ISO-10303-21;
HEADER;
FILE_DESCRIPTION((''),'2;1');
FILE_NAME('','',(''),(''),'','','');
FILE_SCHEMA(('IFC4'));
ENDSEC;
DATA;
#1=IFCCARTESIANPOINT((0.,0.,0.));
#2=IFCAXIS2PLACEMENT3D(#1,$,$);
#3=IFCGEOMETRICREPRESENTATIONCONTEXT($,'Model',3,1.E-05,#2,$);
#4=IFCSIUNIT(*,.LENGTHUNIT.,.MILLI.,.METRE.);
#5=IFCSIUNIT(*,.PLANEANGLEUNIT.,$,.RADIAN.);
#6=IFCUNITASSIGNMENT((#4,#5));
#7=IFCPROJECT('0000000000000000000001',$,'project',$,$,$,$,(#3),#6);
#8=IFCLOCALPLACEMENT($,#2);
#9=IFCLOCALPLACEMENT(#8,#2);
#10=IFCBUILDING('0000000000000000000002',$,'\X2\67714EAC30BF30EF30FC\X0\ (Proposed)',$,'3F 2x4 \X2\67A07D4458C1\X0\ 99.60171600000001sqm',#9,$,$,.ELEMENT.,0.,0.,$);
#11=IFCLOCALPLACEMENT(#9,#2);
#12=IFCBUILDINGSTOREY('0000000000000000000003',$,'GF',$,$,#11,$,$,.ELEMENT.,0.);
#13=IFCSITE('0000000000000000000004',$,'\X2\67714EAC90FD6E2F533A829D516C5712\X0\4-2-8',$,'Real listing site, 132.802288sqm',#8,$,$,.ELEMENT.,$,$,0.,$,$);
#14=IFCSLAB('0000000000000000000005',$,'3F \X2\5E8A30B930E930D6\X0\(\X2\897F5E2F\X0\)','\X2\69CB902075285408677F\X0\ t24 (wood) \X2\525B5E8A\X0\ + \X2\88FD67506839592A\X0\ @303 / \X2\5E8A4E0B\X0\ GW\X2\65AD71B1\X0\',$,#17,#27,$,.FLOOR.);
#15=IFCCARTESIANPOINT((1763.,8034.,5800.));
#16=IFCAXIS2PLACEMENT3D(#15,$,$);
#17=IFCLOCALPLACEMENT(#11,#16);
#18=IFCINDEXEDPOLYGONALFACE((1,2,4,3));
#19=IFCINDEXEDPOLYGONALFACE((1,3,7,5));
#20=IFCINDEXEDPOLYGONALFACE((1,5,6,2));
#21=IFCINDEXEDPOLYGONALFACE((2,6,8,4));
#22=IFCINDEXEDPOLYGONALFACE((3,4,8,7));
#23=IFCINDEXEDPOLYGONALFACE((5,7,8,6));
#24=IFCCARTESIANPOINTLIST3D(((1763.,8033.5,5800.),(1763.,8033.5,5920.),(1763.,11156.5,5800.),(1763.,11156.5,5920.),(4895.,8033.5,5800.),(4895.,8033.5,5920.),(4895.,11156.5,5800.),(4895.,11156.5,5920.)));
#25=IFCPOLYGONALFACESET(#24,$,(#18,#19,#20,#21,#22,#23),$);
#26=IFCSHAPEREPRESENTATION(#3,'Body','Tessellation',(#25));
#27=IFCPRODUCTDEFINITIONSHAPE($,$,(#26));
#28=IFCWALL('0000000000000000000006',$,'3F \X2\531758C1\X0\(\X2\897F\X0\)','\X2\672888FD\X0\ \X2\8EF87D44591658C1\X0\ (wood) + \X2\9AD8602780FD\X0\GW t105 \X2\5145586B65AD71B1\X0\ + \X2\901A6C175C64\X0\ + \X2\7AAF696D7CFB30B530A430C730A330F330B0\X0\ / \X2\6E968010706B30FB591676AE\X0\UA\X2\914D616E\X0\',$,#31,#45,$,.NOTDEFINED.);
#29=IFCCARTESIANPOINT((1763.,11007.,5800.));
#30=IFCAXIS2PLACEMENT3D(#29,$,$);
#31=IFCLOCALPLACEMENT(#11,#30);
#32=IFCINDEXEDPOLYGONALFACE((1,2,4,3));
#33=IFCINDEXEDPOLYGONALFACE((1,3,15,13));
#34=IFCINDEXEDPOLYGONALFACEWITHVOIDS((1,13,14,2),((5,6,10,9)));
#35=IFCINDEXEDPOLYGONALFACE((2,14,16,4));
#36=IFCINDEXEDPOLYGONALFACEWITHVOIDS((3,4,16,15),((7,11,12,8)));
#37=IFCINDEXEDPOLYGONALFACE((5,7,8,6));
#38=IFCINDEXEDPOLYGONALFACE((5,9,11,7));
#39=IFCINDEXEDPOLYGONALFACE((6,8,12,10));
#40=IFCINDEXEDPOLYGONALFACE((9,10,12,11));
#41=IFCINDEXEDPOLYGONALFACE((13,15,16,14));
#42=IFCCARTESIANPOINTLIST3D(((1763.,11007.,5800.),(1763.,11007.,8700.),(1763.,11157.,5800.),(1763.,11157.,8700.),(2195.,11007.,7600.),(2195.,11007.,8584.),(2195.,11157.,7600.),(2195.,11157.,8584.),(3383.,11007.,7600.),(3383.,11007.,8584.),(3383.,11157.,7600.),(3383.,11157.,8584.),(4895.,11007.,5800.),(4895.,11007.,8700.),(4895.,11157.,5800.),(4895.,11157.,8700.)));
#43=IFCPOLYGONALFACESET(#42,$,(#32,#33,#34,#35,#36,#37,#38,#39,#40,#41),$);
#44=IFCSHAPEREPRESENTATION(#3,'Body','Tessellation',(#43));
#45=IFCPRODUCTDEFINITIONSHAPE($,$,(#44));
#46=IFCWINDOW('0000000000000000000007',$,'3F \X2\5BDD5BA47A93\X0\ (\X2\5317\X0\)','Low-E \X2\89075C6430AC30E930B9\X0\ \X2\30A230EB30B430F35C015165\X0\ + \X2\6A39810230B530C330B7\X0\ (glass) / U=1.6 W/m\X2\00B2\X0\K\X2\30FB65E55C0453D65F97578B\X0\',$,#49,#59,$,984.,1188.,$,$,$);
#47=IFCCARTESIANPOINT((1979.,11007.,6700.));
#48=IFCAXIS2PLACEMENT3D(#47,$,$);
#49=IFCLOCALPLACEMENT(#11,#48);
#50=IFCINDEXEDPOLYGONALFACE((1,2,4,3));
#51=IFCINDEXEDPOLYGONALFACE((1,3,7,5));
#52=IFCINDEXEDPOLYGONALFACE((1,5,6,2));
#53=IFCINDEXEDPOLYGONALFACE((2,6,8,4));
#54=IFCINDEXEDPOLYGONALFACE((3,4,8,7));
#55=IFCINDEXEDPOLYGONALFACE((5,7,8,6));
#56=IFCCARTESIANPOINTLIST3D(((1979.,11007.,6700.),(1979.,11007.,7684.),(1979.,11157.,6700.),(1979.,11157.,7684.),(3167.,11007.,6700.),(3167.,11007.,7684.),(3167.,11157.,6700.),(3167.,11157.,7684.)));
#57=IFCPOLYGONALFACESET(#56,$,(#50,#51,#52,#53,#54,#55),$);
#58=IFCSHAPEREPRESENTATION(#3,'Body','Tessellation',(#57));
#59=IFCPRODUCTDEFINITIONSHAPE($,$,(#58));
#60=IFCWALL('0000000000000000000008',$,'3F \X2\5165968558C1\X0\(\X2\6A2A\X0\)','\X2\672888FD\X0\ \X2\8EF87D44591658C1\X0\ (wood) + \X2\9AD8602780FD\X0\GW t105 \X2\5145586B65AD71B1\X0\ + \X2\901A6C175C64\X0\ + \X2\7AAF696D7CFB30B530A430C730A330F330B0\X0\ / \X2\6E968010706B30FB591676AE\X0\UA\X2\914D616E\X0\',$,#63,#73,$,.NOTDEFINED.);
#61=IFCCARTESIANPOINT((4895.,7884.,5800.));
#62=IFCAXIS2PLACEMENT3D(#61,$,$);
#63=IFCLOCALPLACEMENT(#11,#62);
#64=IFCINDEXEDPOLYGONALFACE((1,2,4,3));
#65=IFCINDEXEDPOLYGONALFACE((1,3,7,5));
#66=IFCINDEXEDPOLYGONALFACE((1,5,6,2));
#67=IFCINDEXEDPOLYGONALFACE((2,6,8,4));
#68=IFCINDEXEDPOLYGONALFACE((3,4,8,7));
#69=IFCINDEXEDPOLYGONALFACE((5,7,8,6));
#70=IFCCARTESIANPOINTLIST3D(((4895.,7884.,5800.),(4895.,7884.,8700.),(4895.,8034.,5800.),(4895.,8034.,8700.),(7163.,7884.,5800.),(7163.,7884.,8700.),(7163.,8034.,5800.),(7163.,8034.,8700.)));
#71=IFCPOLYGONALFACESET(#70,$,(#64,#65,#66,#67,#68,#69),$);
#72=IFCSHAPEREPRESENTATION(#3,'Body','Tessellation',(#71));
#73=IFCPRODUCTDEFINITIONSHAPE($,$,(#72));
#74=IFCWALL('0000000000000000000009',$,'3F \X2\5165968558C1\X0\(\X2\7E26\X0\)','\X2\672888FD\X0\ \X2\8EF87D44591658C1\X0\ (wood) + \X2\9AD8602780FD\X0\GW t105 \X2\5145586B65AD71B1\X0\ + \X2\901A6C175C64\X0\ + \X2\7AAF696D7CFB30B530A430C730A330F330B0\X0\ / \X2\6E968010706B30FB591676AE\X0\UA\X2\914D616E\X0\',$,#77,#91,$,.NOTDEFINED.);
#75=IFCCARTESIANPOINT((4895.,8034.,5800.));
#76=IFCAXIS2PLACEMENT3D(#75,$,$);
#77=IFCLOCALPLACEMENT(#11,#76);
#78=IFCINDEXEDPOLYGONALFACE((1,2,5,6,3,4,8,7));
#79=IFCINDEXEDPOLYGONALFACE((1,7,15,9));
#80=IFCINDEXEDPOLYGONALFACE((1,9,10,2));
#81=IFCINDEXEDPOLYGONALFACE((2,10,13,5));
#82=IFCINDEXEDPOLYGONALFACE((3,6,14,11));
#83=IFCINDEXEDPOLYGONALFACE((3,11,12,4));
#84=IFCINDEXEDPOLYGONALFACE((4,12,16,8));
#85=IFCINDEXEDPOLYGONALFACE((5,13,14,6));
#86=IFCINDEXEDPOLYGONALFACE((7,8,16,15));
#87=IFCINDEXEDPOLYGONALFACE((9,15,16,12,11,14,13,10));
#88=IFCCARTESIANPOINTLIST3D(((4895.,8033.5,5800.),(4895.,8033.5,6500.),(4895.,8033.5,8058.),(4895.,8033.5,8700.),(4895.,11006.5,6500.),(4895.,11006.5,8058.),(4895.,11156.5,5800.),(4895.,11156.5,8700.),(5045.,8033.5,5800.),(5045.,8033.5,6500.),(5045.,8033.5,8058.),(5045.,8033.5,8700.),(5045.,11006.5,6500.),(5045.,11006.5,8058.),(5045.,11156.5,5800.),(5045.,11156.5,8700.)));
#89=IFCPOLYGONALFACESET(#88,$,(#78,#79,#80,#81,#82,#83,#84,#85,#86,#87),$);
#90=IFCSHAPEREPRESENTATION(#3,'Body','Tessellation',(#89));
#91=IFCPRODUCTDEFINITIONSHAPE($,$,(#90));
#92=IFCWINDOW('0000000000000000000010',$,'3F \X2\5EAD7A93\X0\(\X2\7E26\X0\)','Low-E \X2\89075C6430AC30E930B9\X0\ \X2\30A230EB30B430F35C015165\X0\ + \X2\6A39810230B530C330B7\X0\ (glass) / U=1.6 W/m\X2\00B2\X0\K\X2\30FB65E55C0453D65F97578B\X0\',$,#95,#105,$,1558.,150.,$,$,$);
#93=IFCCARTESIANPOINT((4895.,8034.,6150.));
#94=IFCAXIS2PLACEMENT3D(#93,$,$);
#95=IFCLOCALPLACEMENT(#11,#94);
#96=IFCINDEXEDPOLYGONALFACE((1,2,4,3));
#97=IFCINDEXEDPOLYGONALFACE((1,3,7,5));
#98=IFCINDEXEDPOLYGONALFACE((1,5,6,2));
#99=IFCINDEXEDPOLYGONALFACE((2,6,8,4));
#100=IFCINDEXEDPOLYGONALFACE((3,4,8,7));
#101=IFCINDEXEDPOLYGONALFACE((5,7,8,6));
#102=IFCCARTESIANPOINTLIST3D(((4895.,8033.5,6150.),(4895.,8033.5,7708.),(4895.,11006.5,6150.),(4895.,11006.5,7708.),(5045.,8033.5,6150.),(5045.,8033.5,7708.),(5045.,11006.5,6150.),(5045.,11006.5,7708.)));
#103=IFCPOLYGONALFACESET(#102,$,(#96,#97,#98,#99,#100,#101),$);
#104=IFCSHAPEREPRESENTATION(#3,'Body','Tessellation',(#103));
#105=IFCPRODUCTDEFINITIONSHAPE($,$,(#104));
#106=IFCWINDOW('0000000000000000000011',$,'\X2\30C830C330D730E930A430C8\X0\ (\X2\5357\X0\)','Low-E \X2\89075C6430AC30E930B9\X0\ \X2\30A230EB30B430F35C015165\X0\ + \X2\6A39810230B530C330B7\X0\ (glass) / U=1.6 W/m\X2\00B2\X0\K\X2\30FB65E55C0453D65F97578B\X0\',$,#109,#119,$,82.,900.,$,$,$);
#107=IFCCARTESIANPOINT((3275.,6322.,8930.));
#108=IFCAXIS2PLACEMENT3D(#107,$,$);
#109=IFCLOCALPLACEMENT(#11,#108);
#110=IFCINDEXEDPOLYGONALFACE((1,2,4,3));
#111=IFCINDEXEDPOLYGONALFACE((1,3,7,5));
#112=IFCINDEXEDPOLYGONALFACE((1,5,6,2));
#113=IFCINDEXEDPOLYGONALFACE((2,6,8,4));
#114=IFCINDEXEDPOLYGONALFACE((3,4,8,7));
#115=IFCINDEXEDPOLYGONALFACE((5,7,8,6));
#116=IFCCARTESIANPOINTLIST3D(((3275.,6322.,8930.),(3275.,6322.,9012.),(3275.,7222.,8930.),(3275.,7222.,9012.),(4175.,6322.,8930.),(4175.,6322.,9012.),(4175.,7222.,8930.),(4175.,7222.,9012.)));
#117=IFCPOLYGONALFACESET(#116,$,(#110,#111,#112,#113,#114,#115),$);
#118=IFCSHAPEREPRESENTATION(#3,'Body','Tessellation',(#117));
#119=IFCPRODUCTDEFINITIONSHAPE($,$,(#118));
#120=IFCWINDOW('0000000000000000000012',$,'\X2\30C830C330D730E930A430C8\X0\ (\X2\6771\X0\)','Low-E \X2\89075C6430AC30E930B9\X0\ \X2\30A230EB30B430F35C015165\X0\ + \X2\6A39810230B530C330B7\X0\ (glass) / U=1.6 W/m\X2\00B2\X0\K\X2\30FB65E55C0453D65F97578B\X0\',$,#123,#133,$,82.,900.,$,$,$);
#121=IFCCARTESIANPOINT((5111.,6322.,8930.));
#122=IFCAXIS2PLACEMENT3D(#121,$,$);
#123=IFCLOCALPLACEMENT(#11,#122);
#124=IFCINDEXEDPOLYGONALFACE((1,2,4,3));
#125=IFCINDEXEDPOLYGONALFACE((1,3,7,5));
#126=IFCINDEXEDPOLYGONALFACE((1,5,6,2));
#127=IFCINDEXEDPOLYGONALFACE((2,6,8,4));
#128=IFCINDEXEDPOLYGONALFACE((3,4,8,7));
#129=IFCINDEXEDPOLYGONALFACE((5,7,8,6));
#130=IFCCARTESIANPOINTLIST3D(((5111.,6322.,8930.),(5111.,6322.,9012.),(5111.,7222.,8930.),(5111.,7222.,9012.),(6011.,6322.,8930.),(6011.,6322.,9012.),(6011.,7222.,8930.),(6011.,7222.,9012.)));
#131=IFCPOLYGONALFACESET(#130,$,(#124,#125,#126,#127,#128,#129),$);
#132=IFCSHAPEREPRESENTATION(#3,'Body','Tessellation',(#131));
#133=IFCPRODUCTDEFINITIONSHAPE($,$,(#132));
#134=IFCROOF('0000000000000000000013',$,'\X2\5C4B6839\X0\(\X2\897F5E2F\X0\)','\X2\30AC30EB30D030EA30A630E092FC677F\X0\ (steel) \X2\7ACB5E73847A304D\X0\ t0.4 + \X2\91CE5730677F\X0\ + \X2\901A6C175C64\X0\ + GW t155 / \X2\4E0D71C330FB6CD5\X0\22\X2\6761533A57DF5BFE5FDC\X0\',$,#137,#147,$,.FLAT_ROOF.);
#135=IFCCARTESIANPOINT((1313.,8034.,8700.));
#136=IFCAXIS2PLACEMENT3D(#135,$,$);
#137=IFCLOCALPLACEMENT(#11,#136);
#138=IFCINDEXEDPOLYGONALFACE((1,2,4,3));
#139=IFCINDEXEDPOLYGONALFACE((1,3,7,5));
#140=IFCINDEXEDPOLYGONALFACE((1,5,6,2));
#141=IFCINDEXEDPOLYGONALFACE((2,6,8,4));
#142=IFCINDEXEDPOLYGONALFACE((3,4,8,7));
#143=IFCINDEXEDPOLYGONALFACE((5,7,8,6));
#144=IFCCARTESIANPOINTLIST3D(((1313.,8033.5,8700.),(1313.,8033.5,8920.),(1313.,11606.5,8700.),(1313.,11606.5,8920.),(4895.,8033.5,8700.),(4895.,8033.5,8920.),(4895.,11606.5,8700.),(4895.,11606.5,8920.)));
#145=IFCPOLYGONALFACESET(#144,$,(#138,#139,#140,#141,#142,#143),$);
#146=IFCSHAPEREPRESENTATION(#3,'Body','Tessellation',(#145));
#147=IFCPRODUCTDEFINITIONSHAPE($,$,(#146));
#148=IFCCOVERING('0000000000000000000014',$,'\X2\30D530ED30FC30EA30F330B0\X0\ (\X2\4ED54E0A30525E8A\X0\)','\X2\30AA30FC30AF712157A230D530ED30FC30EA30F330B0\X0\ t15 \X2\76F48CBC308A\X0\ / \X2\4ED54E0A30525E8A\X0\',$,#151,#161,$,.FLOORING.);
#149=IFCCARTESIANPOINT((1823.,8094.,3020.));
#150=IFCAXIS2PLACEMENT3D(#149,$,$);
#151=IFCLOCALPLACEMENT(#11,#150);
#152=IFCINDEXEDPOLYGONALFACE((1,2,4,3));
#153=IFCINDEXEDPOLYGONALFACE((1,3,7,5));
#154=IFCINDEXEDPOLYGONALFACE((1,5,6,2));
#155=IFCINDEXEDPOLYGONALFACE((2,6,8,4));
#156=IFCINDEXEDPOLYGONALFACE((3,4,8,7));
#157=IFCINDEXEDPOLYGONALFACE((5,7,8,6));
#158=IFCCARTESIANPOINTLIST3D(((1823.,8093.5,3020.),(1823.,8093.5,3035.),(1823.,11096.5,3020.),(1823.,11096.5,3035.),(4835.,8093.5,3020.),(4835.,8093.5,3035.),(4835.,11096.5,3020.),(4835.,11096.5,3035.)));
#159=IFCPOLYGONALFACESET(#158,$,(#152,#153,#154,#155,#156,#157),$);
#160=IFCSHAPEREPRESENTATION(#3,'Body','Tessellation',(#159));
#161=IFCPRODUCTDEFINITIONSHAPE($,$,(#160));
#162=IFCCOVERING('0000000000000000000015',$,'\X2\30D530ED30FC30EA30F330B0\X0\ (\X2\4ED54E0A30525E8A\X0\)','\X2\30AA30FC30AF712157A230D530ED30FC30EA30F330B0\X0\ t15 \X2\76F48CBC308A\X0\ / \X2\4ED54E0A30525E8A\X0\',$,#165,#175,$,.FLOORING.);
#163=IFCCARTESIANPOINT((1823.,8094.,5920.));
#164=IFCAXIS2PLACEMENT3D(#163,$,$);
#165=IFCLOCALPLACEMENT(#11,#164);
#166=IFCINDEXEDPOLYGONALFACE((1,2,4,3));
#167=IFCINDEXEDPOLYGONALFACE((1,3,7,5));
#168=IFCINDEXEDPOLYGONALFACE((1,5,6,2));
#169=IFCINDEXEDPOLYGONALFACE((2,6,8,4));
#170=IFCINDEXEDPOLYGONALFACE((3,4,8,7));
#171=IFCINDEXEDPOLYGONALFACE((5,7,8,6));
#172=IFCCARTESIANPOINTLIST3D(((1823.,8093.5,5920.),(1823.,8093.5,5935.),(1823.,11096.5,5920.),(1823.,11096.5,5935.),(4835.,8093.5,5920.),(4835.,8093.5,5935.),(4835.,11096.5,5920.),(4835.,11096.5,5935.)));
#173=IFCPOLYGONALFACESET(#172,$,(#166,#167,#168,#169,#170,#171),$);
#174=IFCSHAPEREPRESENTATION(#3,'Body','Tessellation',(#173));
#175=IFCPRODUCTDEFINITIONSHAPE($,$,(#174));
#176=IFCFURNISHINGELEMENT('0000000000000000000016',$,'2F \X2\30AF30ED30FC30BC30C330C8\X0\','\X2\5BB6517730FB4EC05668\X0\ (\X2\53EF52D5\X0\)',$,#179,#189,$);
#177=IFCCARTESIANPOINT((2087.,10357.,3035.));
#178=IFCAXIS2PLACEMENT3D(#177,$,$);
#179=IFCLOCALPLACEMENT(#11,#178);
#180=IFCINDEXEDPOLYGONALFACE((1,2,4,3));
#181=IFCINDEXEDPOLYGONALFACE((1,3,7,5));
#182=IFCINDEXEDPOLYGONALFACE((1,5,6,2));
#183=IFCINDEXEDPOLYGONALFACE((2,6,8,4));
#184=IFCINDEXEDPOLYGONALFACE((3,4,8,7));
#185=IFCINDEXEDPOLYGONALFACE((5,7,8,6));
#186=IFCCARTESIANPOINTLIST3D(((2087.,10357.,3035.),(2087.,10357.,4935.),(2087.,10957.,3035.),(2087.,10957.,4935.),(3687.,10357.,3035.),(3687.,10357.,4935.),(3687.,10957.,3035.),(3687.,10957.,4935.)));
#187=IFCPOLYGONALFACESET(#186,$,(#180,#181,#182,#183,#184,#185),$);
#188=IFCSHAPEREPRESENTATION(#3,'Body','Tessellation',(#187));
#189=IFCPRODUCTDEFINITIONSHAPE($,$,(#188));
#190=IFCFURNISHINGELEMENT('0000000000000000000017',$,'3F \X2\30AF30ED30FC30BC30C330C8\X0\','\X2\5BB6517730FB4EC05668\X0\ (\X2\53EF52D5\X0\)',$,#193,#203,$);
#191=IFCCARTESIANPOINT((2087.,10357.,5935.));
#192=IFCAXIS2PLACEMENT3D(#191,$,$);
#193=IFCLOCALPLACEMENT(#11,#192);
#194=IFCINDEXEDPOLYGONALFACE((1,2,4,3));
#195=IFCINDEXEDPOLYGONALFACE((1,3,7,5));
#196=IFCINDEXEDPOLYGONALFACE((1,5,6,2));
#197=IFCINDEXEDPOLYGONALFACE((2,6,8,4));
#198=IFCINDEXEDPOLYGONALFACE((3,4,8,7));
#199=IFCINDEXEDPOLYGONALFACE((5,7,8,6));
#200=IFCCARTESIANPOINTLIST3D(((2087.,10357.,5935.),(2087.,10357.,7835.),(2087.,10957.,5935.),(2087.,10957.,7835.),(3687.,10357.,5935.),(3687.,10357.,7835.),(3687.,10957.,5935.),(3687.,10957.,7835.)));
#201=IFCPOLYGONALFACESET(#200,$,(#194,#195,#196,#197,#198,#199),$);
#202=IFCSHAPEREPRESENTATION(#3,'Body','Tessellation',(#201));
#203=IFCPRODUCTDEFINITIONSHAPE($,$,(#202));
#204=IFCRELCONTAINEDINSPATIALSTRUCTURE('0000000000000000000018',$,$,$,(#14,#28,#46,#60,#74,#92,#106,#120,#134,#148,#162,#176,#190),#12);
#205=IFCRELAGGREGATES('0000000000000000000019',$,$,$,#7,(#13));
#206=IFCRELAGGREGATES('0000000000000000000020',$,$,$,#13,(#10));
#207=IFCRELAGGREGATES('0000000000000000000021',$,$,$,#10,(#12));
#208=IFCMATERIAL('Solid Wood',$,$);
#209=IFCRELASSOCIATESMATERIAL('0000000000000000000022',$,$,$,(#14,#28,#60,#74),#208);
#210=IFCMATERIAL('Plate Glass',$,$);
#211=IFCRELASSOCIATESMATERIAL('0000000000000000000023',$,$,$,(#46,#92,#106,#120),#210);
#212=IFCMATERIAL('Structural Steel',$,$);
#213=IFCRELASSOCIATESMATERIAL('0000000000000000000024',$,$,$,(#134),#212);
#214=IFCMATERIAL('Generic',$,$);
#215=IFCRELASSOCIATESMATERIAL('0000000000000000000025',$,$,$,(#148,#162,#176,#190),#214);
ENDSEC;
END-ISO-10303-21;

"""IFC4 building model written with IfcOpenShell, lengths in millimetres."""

from ifc_helpers import new_model, si_unit, frame, frame_2d, origin, place, context, project, spatial, rectangle, extrude, material, element, fill, save


model = new_model("IFC4")

# Units and contexts
model_context = context("Model", 3, precision=1e-05, world=origin())
ifc_project = project(units=[si_unit("LENGTHUNIT", "METRE", prefix="MILLI"), si_unit("PLANEANGLEUNIT", "RADIAN")], contexts=[model_context])

# Site, building, storey
site_placement = place(None, origin())
site = spatial("IfcSite", under=ifc_project, at=site_placement, Name="東京都港区芝公園4-2-8", ObjectType="Real listing site, 132.802288sqm", CompositionType="ELEMENT", RefElevation=0.0)
building_placement = place(site_placement, origin())
building = spatial("IfcBuilding", under=site, at=building_placement, Name="東京タワー (Proposed)", ObjectType="3F 2x4 枠組壁 99.60171600000001sqm", CompositionType="ELEMENT", ElevationOfRefHeight=0.0, ElevationOfTerrain=0.0)
storey_placement = place(building_placement, origin())
storey = spatial("IfcBuildingStorey", under=building, at=storey_placement, Name="GF", CompositionType="ELEMENT", Elevation=0.0)

# Slab
ifc_material_1 = material(Name="Solid Wood")
slab_placement = place(storey_placement, frame((1763.0, 8034.0, 5800.0)))
element("IfcSlab", 1, at=slab_placement, inside=storey, material=ifc_material_1, Name="3F 床スラブ(西帯)", Description="構造用合板 t24 (wood) 剛床 + 製材根太 @303 / 床下 GW断熱", PredefinedType="FLOOR", context=model_context, shape_type="SweptSolid", body=[
    extrude(rectangle(XDim=3132.0, YDim=3123.0, at=frame_2d((1566.0, 1561.0))), frame((1763.0, 8034.0, 5800.0)), (0.0, 0.0, 1.0), 120.0),
])

# Wall, opening, window
wall_1_placement = place(storey_placement, frame((1763.0, 11007.0, 5800.0)))
wall_1 = element("IfcWall", 2, at=wall_1_placement, inside=storey, material=ifc_material_1, Name="3F 北壁(西)", Description="木製 軸組外壁 (wood) + 高性能GW t105 充填断熱 + 通気層 + 窯業系サイディング / 準耐火・外皮UA配慮", PredefinedType="NOTDEFINED", context=model_context, shape_type="SweptSolid", body=[
    extrude(rectangle(XDim=3132.0, YDim=150.0, at=frame_2d((1566.0, 75.0))), frame((1763.0, 11007.0, 5800.0)), (0.0, 0.0, 1.0), 2900.0),
])
opening_1_placement = place(storey_placement, frame((1979.0, 11007.0, 6700.0)))
opening_1 = element("IfcOpeningElement", 3, at=opening_1_placement, cuts=wall_1, PredefinedType="NOTDEFINED", context=model_context, shape_type="SweptSolid", body=[
    extrude(rectangle(XDim=1188.0, YDim=150.0, at=frame_2d((594.0, 75.0))), frame((1979.0, 11007.0, 6700.0)), (0.0, 0.0, 1.0), 984.0),
])
ifc_material_2 = material(Name="Plate Glass")
window_1_placement = place(storey_placement, frame((1979.0, 11007.0, 6700.0)))
window_1 = element("IfcWindow", 4, at=window_1_placement, inside=storey, material=ifc_material_2, Name="3F 寝室窓 (北)", Description="Low-E 複層ガラス アルゴン封入 + 樹脂サッシ (glass) / U=1.6 W/m²K・日射取得型", OverallHeight=984.0, OverallWidth=1188.0, context=model_context, shape_type="SweptSolid", body=[
    extrude(rectangle(XDim=1188.0, YDim=150.0, at=frame_2d((594.0, 75.0))), frame((1979.0, 11007.0, 6700.0)), (0.0, 0.0, 1.0), 984.0),
])
fill(opening_1, window_1)

# Wall
wall_2_placement = place(storey_placement, frame((4895.0, 7884.0, 5800.0)))
element("IfcWall", 5, at=wall_2_placement, inside=storey, material=ifc_material_1, Name="3F 入隅壁(横)", Description="木製 軸組外壁 (wood) + 高性能GW t105 充填断熱 + 通気層 + 窯業系サイディング / 準耐火・外皮UA配慮", PredefinedType="NOTDEFINED", context=model_context, shape_type="SweptSolid", body=[
    extrude(rectangle(XDim=2268.0, YDim=150.0, at=frame_2d((1134.0, 75.0))), frame((4895.0, 7884.0, 5800.0)), (0.0, 0.0, 1.0), 2900.0),
])

# Wall, opening, window
wall_3_placement = place(storey_placement, frame((4895.0, 8034.0, 5800.0)))
wall_3 = element("IfcWall", 6, at=wall_3_placement, inside=storey, material=ifc_material_1, Name="3F 入隅壁(縦)", Description="木製 軸組外壁 (wood) + 高性能GW t105 充填断熱 + 通気層 + 窯業系サイディング / 準耐火・外皮UA配慮", PredefinedType="NOTDEFINED", context=model_context, shape_type="SweptSolid", body=[
    extrude(rectangle(XDim=150.0, YDim=3123.0, at=frame_2d((75.0, 1561.0))), frame((4895.0, 8034.0, 5800.0)), (0.0, 0.0, 1.0), 2900.0),
])
opening_2_placement = place(storey_placement, frame((4895.0, 8034.0, 6150.0)))
opening_2 = element("IfcOpeningElement", 7, at=opening_2_placement, cuts=wall_3, PredefinedType="NOTDEFINED", context=model_context, shape_type="SweptSolid", body=[
    extrude(rectangle(XDim=150.0, YDim=2973.0, at=frame_2d((75.0, 1486.0))), frame((4895.0, 8034.0, 6150.0)), (0.0, 0.0, 1.0), 1558.0),
])
window_2_placement = place(storey_placement, frame((4895.0, 8034.0, 6150.0)))
window_2 = element("IfcWindow", 8, at=window_2_placement, inside=storey, material=ifc_material_2, Name="3F 庭窓(縦)", Description="Low-E 複層ガラス アルゴン封入 + 樹脂サッシ (glass) / U=1.6 W/m²K・日射取得型", OverallHeight=1558.0, OverallWidth=150.0, context=model_context, shape_type="SweptSolid", body=[
    extrude(rectangle(XDim=150.0, YDim=2973.0, at=frame_2d((75.0, 1486.0))), frame((4895.0, 8034.0, 6150.0)), (0.0, 0.0, 1.0), 1558.0),
])
fill(opening_2, window_2)

# Windows
window_3_placement = place(storey_placement, frame((3275.0, 6322.0, 8930.0)))
element("IfcWindow", 9, at=window_3_placement, inside=storey, material=ifc_material_2, Name="トップライト (南)", Description="Low-E 複層ガラス アルゴン封入 + 樹脂サッシ (glass) / U=1.6 W/m²K・日射取得型", OverallHeight=82.0, OverallWidth=900.0, context=model_context, shape_type="SweptSolid", body=[
    extrude(rectangle(XDim=900.0, YDim=900.0, at=frame_2d((450.0, 450.0))), frame((3275.0, 6322.0, 8930.0)), (0.0, 0.0, 1.0), 82.0),
])
window_4_placement = place(storey_placement, frame((5111.0, 6322.0, 8930.0)))
element("IfcWindow", 10, at=window_4_placement, inside=storey, material=ifc_material_2, Name="トップライト (東)", Description="Low-E 複層ガラス アルゴン封入 + 樹脂サッシ (glass) / U=1.6 W/m²K・日射取得型", OverallHeight=82.0, OverallWidth=900.0, context=model_context, shape_type="SweptSolid", body=[
    extrude(rectangle(XDim=900.0, YDim=900.0, at=frame_2d((450.0, 450.0))), frame((5111.0, 6322.0, 8930.0)), (0.0, 0.0, 1.0), 82.0),
])

# Roof
ifc_material_3 = material(Name="Structural Steel")
for number, where, name in (
    (11, (1313.0, 8034.0, 8700.0), "屋根(西帯)"),
):
    element("IfcRoof", number, at=place(storey_placement, frame(where)), inside=storey, material=ifc_material_3, Name=name, Description="ガルバリウム鋼板 (steel) 立平葺き t0.4 + 野地板 + 通気層 + GW t155 / 不燃・法22条区域対応", PredefinedType="FLAT_ROOF", context=model_context, shape_type="SweptSolid", body=[
        extrude(rectangle(XDim=3582.0, YDim=3573.0, at=frame_2d((1791.0, 1786.0))), frame((1313.0, 8034.0, 8700.0)), (0.0, 0.0, 1.0), 220.0),
    ])

# Coverings
ifc_material_4 = material(Name="Generic")
covering_1_placement = place(storey_placement, frame((1823.0, 8094.0, 3020.0)))
element("IfcCovering", 12, at=covering_1_placement, inside=storey, material=ifc_material_4, Name="フローリング (仕上げ床)", Description="オーク無垢フローリング t15 直貼り / 仕上げ床", PredefinedType="FLOORING", context=model_context, shape_type="SweptSolid", body=[
    extrude(rectangle(XDim=3012.0, YDim=3003.0, at=frame_2d((1506.0, 1501.0))), frame((1823.0, 8094.0, 3020.0)), (0.0, 0.0, 1.0), 15.0),
])
covering_2_placement = place(storey_placement, frame((1823.0, 8094.0, 5920.0)))
element("IfcCovering", 13, at=covering_2_placement, inside=storey, material=ifc_material_4, Name="フローリング (仕上げ床)", Description="オーク無垢フローリング t15 直貼り / 仕上げ床", PredefinedType="FLOORING", context=model_context, shape_type="SweptSolid", body=[
    extrude(rectangle(XDim=3012.0, YDim=3003.0, at=frame_2d((1506.0, 1501.0))), frame((1823.0, 8094.0, 5920.0)), (0.0, 0.0, 1.0), 15.0),
])

# Furnishing elements
furnishing_1_placement = place(storey_placement, frame((2087.0, 10357.0, 3035.0)))
element("IfcFurnishingElement", 14, at=furnishing_1_placement, inside=storey, material=ifc_material_4, Name="2F クローゼット", Description="家具・什器 (可動)", context=model_context, shape_type="SweptSolid", body=[
    extrude(rectangle(XDim=1600.0, YDim=600.0, at=frame_2d((800.0, 300.0))), frame((2087.0, 10357.0, 3035.0)), (0.0, 0.0, 1.0), 1900.0),
])
furnishing_2_placement = place(storey_placement, frame((2087.0, 10357.0, 5935.0)))
element("IfcFurnishingElement", 15, at=furnishing_2_placement, inside=storey, material=ifc_material_4, Name="3F クローゼット", Description="家具・什器 (可動)", context=model_context, shape_type="SweptSolid", body=[
    extrude(rectangle(XDim=1600.0, YDim=600.0, at=frame_2d((800.0, 300.0))), frame((2087.0, 10357.0, 5935.0)), (0.0, 0.0, 1.0), 1900.0),
])

save(model, "model.ifc")
